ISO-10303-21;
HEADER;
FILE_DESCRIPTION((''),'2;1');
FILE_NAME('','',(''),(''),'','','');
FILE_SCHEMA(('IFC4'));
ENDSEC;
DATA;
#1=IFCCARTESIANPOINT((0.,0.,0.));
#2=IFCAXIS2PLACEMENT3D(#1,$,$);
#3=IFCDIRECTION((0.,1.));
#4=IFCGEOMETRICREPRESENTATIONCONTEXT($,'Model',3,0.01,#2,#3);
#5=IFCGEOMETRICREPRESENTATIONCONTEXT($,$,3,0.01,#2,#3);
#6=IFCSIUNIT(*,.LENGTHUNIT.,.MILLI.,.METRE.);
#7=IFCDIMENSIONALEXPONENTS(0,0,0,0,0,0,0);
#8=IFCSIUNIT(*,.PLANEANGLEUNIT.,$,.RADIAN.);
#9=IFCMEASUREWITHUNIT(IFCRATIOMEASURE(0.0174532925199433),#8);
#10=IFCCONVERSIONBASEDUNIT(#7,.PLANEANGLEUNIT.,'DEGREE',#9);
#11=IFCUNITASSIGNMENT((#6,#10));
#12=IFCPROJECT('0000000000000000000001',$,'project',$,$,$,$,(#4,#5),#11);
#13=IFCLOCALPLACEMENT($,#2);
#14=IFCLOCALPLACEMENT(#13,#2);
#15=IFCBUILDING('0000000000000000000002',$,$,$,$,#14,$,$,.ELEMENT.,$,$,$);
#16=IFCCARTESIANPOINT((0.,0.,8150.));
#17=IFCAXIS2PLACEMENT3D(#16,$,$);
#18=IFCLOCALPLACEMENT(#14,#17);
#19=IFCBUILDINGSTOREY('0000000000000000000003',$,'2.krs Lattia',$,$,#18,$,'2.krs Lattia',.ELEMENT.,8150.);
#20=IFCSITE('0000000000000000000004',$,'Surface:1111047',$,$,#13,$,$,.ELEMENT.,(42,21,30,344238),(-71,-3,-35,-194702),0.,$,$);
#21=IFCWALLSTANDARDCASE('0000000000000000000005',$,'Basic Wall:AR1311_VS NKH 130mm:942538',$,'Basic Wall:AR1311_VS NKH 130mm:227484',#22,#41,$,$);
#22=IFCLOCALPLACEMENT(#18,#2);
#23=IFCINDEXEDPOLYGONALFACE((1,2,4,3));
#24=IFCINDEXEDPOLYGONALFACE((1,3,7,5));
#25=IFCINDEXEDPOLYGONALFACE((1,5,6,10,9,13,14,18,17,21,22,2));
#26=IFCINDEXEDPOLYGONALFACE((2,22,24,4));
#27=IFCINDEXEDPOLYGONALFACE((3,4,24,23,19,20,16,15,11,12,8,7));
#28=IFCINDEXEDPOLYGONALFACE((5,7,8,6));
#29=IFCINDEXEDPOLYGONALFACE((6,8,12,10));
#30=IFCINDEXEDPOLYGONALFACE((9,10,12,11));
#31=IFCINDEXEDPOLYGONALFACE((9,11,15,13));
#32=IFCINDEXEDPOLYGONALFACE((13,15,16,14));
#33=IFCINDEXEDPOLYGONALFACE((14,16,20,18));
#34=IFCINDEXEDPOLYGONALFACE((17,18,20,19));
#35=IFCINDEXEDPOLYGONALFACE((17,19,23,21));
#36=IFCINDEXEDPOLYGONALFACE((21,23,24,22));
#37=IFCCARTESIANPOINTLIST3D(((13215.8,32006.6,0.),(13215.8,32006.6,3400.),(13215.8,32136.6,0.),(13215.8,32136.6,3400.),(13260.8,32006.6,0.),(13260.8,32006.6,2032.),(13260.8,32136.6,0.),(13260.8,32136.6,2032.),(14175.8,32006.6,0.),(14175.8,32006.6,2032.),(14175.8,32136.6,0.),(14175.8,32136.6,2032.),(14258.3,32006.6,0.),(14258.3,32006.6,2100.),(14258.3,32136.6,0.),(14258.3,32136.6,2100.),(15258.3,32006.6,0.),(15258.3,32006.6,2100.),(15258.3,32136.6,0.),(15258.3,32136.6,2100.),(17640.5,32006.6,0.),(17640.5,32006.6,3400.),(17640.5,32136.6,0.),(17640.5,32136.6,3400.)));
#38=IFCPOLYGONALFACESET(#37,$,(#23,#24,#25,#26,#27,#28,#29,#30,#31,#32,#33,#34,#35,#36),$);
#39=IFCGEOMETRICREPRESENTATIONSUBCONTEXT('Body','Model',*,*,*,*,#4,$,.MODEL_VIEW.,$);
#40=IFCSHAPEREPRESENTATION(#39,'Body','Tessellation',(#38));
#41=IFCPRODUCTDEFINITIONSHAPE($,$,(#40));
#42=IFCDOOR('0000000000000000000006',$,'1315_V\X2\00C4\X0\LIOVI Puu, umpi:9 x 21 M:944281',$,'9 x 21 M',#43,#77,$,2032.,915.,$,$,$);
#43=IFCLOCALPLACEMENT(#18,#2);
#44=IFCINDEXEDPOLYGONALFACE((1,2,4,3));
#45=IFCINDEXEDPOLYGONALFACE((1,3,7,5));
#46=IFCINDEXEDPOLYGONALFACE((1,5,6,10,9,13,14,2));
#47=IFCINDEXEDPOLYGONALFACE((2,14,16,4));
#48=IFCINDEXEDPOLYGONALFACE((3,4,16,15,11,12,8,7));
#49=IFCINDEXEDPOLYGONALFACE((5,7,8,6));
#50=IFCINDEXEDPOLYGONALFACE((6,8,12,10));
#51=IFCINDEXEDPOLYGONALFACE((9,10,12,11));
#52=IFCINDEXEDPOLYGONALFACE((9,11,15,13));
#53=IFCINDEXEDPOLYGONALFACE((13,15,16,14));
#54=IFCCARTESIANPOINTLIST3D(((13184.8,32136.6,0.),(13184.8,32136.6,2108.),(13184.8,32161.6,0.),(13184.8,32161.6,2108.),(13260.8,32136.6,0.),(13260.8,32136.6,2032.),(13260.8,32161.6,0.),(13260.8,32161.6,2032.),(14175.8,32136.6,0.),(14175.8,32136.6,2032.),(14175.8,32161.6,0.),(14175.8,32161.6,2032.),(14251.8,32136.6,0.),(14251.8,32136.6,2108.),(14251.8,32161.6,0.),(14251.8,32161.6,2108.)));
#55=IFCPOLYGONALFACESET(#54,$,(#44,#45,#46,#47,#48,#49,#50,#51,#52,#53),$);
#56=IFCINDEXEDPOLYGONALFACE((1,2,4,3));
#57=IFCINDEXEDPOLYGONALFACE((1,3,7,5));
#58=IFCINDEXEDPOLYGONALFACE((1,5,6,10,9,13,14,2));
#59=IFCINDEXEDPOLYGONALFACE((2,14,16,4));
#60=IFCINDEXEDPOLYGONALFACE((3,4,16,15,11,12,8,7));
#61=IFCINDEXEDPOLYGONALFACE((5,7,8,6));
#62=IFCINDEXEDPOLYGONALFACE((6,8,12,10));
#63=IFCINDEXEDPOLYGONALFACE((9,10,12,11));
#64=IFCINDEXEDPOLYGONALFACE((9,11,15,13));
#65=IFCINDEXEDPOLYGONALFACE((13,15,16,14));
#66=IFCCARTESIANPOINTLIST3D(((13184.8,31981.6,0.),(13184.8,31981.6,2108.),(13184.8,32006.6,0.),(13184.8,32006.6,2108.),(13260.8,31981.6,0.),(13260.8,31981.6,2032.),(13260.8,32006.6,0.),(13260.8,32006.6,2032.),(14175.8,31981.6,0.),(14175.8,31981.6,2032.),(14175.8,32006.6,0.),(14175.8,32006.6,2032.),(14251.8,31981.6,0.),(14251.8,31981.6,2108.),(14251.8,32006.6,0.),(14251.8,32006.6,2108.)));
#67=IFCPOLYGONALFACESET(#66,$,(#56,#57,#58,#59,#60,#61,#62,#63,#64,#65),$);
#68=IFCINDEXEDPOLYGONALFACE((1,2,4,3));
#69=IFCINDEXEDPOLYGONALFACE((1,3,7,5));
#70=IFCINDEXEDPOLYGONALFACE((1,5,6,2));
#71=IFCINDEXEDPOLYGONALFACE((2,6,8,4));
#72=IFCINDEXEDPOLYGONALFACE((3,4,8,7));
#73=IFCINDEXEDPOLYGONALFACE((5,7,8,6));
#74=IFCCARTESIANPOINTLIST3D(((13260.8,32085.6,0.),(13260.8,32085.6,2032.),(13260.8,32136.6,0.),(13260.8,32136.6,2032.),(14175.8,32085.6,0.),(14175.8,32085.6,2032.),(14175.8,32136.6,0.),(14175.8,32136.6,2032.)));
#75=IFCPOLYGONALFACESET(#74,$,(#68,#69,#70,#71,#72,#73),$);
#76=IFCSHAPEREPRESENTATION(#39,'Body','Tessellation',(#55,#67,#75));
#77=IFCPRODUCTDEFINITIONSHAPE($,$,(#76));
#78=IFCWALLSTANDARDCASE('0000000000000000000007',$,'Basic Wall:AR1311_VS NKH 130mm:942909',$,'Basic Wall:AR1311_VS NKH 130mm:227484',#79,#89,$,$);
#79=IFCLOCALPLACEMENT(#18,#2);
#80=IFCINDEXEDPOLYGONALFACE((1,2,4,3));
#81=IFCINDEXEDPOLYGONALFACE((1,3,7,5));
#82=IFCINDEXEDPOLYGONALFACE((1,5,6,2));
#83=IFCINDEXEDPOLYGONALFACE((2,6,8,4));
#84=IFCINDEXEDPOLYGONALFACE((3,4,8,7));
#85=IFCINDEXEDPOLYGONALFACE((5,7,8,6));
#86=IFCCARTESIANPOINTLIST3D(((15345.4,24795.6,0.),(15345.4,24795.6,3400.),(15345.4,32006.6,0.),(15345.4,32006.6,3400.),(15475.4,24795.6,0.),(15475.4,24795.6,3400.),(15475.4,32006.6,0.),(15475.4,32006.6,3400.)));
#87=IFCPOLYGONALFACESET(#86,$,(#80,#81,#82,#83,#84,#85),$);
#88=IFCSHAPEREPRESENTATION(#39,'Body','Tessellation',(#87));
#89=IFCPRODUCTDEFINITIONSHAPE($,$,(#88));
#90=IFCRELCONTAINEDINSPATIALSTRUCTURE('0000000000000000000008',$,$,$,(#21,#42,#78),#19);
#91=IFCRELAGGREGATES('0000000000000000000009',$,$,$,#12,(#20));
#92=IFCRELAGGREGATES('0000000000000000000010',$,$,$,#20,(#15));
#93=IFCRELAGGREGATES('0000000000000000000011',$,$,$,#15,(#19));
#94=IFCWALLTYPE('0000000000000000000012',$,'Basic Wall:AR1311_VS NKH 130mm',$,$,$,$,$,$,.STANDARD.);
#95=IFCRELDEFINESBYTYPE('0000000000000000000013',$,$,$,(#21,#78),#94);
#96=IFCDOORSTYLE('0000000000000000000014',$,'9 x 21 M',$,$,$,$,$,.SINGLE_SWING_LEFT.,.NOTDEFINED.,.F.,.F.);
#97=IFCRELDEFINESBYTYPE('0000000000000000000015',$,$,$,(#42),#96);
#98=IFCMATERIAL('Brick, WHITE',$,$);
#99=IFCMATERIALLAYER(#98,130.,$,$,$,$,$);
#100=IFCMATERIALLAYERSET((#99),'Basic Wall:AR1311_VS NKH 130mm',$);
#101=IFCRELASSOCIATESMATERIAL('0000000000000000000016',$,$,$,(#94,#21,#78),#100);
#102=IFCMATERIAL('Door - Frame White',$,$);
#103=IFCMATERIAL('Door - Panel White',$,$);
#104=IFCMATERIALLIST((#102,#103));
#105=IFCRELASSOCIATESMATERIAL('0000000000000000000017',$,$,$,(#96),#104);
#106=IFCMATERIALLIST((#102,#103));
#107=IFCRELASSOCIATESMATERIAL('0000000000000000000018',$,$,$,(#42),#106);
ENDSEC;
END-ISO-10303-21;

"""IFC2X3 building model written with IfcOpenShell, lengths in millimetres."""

from ifc_helpers import new_model, entity, si_unit, converted_unit, direction, frame, frame_2d, origin, place, context, subcontext, project, spatial, polyline, rectangle, outline, extrude, source, transform, mapped, material, material_list, layer, layer_set, layer_usage, type_object, type_shapes, element, fill, save


model = new_model("IFC2X3")

# Units and contexts
model_context = context("Model", 3, precision=0.01, world=origin(), true_north=direction((0.0, 1.0)))
context_of_model = context(None, 3, precision=0.01, world=origin(), true_north=direction((0.0, 1.0)))
body_context = subcontext(model_context, "Body", "Model", "MODEL_VIEW")
ifc_project = project(units=[si_unit("LENGTHUNIT", "METRE", prefix="MILLI"), converted_unit("PLANEANGLEUNIT", "DEGREE", entity("IfcRatioMeasure", 0.0174532925199433), si_unit("PLANEANGLEUNIT", "RADIAN"), dimensions=[0, 0, 0, 0, 0, 0, 0])], contexts=[model_context, context_of_model])

# Site, building, storey
site_placement = place(None, origin())
site = spatial("IfcSite", under=ifc_project, at=site_placement, Name="Surface:1111047", CompositionType="ELEMENT", RefLatitude=(42, 21, 30, 344238), RefLongitude=(-71, -3, -35, -194702), RefElevation=0.0)
building_placement = place(site_placement, origin())
building = spatial("IfcBuilding", under=site, at=building_placement, CompositionType="ELEMENT")
storey_placement = place(building_placement, frame((0.0, 0.0, 8150.0)))
storey = spatial("IfcBuildingStorey", under=building, at=storey_placement, Name="2.krs Lattia", LongName="2.krs Lattia", CompositionType="ELEMENT", Elevation=8150.0)

# Shared definitions
ifc_material_1 = material(Name="Brick, WHITE")
ifc_layer = layer(ifc_material_1, 130.0)
ifc_layer_set = layer_set([ifc_layer], Name="Basic Wall:AR1311_VS NKH 130mm")
wall_type = type_object("IfcWallType", Name="Basic Wall:AR1311_VS NKH 130mm", PredefinedType="STANDARD", material=ifc_layer_set)

# Wall, openings, door
ifc_material_2 = material(Name="Door - Frame White")
ifc_material_3 = material(Name="Door - Panel White")
ifc_material_list_1 = material_list([ifc_material_2, ifc_material_3])
door_style = type_object("IfcDoorStyle", Name="9 x 21 M", ConstructionType="NOTDEFINED", OperationType="SINGLE_SWING_LEFT", ParameterTakesPrecedence=False, Sizeable=False, material=ifc_material_list_1)
shared_shape_1 = source(origin(), body_context, "Body", "SweptSolid", [
    extrude(outline(polyline([(-533.5, -1073.0), (533.5, -1073.0), (533.5, 1035.0), (457.5, 1035.0), (457.5, -997.0), (-457.5, -997.0), (-457.5, 1035.0), (-533.5, 1035.0), (-533.5, -1073.0)])), frame((457.5, 155.0, 1035.0), z_axis=(0.0, -1.0, 0.0), x_axis=(-1.0, 0.0, 0.0)), (0.0, 0.0, 1.0), 25.0),
    extrude(outline(polyline([(-1073.0, -533.5), (1035.0, -533.5), (1035.0, -457.5), (-997.0, -457.5), (-997.0, 457.5), (1035.0, 457.5), (1035.0, 533.5), (-1073.0, 533.5), (-1073.0, -533.5)])), frame((457.5, 0.0, 1035.0), z_axis=(0.0, -1.0, 0.0), x_axis=(0.0, 0.0, -1.0)), (0.0, 0.0, 1.0), 25.0),
    extrude(rectangle(XDim=915.0, YDim=51.0, at=frame_2d((0.0, 0.0), x_axis=(1.0, 0.0))), frame((457.5, 104.5, 0.0)), (0.0, 0.0, 1.0), 2032.0),
])
type_shapes(door_style, [shared_shape_1])
ifc_layer_usage_1 = layer_usage(ifc_layer_set, "AXIS2", "NEGATIVE", 65.0)
wall_1_placement = place(storey_placement, frame((13215.8, 32071.6, 0.0)))
wall_1 = element("IfcWallStandardCase", 1, at=wall_1_placement, inside=storey, type_object=wall_type, material=ifc_layer_usage_1, Name="Basic Wall:AR1311_VS NKH 130mm:942538", ObjectType="Basic Wall:AR1311_VS NKH 130mm:227484", context=body_context, shape_type="SweptSolid", body=[
    extrude(rectangle(XDim=4424.8, YDim=130.0, at=frame_2d((2212.4, 0.0), x_axis=(-1.0, 0.0))), origin(), (0.0, 0.0, 1.0), 3400.0),
])
opening_1_placement = place(wall_1_placement, origin())
element("IfcOpeningElement", 2, at=opening_1_placement, cuts=wall_1, ObjectType="Opening", context=body_context, shape_type="SweptSolid", body=[
    extrude(rectangle(XDim=2100.0, YDim=1000.0, at=frame_2d((0.0, 0.0), x_axis=(1.0, 0.0))), frame((1542.5, -65.0, 1050.0), z_axis=(0.0, 1.0, 0.0), x_axis=(0.0, 0.0, -1.0)), (0.0, 0.0, 1.0), 130.0),
])
opening_2_placement = place(wall_1_placement, frame((45.0, -65.0, 0.0)))
opening_2 = element("IfcOpeningElement", 3, at=opening_2_placement, cuts=wall_1, ObjectType="Opening", context=body_context, shape_type="SweptSolid", body=[
    extrude(rectangle(XDim=915.0, YDim=2032.0, at=frame_2d((1016.0, 457.5), x_axis=(0.0, -1.0))), frame((0.0, 0.0, 0.0), z_axis=(0.0, 1.0, 0.0), x_axis=(0.0, 0.0, 1.0)), (0.0, 0.0, 1.0), 130.0),
])
ifc_material_list_2 = material_list([ifc_material_2, ifc_material_3])
door_1_placement = place(opening_2_placement, origin())
door_1 = element("IfcDoor", 4, at=door_1_placement, inside=storey, type_object=door_style, material=ifc_material_list_2, Name="1315_VÄLIOVI Puu, umpi:9 x 21 M:944281", ObjectType="9 x 21 M", OverallHeight=2032.0, OverallWidth=915.0, context=body_context, shape_type="MappedRepresentation", body=[
    mapped(shared_shape_1, transform((0.0, 0.0, 0.0), scale=1.0)),
])
fill(opening_2, door_1)

# Wall
ifc_layer_usage_2 = layer_usage(ifc_layer_set, "AXIS2", "NEGATIVE", 65.0)
wall_2_placement = place(storey_placement, frame((15410.4, 32006.6, 0.0), z_axis=(0.0, 0.0, 1.0), x_axis=(0.0, -1.0, 0.0)))
element("IfcWallStandardCase", 5, at=wall_2_placement, inside=storey, type_object=wall_type, material=ifc_layer_usage_2, Name="Basic Wall:AR1311_VS NKH 130mm:942909", ObjectType="Basic Wall:AR1311_VS NKH 130mm:227484", context=body_context, shape_type="SweptSolid", body=[
    extrude(rectangle(XDim=7211.0, YDim=130.0, at=frame_2d((3605.5, 0.0), x_axis=(-1.0, 0.0))), origin(), (0.0, 0.0, 1.0), 3400.0),
])

save(model, "model.ifc")
